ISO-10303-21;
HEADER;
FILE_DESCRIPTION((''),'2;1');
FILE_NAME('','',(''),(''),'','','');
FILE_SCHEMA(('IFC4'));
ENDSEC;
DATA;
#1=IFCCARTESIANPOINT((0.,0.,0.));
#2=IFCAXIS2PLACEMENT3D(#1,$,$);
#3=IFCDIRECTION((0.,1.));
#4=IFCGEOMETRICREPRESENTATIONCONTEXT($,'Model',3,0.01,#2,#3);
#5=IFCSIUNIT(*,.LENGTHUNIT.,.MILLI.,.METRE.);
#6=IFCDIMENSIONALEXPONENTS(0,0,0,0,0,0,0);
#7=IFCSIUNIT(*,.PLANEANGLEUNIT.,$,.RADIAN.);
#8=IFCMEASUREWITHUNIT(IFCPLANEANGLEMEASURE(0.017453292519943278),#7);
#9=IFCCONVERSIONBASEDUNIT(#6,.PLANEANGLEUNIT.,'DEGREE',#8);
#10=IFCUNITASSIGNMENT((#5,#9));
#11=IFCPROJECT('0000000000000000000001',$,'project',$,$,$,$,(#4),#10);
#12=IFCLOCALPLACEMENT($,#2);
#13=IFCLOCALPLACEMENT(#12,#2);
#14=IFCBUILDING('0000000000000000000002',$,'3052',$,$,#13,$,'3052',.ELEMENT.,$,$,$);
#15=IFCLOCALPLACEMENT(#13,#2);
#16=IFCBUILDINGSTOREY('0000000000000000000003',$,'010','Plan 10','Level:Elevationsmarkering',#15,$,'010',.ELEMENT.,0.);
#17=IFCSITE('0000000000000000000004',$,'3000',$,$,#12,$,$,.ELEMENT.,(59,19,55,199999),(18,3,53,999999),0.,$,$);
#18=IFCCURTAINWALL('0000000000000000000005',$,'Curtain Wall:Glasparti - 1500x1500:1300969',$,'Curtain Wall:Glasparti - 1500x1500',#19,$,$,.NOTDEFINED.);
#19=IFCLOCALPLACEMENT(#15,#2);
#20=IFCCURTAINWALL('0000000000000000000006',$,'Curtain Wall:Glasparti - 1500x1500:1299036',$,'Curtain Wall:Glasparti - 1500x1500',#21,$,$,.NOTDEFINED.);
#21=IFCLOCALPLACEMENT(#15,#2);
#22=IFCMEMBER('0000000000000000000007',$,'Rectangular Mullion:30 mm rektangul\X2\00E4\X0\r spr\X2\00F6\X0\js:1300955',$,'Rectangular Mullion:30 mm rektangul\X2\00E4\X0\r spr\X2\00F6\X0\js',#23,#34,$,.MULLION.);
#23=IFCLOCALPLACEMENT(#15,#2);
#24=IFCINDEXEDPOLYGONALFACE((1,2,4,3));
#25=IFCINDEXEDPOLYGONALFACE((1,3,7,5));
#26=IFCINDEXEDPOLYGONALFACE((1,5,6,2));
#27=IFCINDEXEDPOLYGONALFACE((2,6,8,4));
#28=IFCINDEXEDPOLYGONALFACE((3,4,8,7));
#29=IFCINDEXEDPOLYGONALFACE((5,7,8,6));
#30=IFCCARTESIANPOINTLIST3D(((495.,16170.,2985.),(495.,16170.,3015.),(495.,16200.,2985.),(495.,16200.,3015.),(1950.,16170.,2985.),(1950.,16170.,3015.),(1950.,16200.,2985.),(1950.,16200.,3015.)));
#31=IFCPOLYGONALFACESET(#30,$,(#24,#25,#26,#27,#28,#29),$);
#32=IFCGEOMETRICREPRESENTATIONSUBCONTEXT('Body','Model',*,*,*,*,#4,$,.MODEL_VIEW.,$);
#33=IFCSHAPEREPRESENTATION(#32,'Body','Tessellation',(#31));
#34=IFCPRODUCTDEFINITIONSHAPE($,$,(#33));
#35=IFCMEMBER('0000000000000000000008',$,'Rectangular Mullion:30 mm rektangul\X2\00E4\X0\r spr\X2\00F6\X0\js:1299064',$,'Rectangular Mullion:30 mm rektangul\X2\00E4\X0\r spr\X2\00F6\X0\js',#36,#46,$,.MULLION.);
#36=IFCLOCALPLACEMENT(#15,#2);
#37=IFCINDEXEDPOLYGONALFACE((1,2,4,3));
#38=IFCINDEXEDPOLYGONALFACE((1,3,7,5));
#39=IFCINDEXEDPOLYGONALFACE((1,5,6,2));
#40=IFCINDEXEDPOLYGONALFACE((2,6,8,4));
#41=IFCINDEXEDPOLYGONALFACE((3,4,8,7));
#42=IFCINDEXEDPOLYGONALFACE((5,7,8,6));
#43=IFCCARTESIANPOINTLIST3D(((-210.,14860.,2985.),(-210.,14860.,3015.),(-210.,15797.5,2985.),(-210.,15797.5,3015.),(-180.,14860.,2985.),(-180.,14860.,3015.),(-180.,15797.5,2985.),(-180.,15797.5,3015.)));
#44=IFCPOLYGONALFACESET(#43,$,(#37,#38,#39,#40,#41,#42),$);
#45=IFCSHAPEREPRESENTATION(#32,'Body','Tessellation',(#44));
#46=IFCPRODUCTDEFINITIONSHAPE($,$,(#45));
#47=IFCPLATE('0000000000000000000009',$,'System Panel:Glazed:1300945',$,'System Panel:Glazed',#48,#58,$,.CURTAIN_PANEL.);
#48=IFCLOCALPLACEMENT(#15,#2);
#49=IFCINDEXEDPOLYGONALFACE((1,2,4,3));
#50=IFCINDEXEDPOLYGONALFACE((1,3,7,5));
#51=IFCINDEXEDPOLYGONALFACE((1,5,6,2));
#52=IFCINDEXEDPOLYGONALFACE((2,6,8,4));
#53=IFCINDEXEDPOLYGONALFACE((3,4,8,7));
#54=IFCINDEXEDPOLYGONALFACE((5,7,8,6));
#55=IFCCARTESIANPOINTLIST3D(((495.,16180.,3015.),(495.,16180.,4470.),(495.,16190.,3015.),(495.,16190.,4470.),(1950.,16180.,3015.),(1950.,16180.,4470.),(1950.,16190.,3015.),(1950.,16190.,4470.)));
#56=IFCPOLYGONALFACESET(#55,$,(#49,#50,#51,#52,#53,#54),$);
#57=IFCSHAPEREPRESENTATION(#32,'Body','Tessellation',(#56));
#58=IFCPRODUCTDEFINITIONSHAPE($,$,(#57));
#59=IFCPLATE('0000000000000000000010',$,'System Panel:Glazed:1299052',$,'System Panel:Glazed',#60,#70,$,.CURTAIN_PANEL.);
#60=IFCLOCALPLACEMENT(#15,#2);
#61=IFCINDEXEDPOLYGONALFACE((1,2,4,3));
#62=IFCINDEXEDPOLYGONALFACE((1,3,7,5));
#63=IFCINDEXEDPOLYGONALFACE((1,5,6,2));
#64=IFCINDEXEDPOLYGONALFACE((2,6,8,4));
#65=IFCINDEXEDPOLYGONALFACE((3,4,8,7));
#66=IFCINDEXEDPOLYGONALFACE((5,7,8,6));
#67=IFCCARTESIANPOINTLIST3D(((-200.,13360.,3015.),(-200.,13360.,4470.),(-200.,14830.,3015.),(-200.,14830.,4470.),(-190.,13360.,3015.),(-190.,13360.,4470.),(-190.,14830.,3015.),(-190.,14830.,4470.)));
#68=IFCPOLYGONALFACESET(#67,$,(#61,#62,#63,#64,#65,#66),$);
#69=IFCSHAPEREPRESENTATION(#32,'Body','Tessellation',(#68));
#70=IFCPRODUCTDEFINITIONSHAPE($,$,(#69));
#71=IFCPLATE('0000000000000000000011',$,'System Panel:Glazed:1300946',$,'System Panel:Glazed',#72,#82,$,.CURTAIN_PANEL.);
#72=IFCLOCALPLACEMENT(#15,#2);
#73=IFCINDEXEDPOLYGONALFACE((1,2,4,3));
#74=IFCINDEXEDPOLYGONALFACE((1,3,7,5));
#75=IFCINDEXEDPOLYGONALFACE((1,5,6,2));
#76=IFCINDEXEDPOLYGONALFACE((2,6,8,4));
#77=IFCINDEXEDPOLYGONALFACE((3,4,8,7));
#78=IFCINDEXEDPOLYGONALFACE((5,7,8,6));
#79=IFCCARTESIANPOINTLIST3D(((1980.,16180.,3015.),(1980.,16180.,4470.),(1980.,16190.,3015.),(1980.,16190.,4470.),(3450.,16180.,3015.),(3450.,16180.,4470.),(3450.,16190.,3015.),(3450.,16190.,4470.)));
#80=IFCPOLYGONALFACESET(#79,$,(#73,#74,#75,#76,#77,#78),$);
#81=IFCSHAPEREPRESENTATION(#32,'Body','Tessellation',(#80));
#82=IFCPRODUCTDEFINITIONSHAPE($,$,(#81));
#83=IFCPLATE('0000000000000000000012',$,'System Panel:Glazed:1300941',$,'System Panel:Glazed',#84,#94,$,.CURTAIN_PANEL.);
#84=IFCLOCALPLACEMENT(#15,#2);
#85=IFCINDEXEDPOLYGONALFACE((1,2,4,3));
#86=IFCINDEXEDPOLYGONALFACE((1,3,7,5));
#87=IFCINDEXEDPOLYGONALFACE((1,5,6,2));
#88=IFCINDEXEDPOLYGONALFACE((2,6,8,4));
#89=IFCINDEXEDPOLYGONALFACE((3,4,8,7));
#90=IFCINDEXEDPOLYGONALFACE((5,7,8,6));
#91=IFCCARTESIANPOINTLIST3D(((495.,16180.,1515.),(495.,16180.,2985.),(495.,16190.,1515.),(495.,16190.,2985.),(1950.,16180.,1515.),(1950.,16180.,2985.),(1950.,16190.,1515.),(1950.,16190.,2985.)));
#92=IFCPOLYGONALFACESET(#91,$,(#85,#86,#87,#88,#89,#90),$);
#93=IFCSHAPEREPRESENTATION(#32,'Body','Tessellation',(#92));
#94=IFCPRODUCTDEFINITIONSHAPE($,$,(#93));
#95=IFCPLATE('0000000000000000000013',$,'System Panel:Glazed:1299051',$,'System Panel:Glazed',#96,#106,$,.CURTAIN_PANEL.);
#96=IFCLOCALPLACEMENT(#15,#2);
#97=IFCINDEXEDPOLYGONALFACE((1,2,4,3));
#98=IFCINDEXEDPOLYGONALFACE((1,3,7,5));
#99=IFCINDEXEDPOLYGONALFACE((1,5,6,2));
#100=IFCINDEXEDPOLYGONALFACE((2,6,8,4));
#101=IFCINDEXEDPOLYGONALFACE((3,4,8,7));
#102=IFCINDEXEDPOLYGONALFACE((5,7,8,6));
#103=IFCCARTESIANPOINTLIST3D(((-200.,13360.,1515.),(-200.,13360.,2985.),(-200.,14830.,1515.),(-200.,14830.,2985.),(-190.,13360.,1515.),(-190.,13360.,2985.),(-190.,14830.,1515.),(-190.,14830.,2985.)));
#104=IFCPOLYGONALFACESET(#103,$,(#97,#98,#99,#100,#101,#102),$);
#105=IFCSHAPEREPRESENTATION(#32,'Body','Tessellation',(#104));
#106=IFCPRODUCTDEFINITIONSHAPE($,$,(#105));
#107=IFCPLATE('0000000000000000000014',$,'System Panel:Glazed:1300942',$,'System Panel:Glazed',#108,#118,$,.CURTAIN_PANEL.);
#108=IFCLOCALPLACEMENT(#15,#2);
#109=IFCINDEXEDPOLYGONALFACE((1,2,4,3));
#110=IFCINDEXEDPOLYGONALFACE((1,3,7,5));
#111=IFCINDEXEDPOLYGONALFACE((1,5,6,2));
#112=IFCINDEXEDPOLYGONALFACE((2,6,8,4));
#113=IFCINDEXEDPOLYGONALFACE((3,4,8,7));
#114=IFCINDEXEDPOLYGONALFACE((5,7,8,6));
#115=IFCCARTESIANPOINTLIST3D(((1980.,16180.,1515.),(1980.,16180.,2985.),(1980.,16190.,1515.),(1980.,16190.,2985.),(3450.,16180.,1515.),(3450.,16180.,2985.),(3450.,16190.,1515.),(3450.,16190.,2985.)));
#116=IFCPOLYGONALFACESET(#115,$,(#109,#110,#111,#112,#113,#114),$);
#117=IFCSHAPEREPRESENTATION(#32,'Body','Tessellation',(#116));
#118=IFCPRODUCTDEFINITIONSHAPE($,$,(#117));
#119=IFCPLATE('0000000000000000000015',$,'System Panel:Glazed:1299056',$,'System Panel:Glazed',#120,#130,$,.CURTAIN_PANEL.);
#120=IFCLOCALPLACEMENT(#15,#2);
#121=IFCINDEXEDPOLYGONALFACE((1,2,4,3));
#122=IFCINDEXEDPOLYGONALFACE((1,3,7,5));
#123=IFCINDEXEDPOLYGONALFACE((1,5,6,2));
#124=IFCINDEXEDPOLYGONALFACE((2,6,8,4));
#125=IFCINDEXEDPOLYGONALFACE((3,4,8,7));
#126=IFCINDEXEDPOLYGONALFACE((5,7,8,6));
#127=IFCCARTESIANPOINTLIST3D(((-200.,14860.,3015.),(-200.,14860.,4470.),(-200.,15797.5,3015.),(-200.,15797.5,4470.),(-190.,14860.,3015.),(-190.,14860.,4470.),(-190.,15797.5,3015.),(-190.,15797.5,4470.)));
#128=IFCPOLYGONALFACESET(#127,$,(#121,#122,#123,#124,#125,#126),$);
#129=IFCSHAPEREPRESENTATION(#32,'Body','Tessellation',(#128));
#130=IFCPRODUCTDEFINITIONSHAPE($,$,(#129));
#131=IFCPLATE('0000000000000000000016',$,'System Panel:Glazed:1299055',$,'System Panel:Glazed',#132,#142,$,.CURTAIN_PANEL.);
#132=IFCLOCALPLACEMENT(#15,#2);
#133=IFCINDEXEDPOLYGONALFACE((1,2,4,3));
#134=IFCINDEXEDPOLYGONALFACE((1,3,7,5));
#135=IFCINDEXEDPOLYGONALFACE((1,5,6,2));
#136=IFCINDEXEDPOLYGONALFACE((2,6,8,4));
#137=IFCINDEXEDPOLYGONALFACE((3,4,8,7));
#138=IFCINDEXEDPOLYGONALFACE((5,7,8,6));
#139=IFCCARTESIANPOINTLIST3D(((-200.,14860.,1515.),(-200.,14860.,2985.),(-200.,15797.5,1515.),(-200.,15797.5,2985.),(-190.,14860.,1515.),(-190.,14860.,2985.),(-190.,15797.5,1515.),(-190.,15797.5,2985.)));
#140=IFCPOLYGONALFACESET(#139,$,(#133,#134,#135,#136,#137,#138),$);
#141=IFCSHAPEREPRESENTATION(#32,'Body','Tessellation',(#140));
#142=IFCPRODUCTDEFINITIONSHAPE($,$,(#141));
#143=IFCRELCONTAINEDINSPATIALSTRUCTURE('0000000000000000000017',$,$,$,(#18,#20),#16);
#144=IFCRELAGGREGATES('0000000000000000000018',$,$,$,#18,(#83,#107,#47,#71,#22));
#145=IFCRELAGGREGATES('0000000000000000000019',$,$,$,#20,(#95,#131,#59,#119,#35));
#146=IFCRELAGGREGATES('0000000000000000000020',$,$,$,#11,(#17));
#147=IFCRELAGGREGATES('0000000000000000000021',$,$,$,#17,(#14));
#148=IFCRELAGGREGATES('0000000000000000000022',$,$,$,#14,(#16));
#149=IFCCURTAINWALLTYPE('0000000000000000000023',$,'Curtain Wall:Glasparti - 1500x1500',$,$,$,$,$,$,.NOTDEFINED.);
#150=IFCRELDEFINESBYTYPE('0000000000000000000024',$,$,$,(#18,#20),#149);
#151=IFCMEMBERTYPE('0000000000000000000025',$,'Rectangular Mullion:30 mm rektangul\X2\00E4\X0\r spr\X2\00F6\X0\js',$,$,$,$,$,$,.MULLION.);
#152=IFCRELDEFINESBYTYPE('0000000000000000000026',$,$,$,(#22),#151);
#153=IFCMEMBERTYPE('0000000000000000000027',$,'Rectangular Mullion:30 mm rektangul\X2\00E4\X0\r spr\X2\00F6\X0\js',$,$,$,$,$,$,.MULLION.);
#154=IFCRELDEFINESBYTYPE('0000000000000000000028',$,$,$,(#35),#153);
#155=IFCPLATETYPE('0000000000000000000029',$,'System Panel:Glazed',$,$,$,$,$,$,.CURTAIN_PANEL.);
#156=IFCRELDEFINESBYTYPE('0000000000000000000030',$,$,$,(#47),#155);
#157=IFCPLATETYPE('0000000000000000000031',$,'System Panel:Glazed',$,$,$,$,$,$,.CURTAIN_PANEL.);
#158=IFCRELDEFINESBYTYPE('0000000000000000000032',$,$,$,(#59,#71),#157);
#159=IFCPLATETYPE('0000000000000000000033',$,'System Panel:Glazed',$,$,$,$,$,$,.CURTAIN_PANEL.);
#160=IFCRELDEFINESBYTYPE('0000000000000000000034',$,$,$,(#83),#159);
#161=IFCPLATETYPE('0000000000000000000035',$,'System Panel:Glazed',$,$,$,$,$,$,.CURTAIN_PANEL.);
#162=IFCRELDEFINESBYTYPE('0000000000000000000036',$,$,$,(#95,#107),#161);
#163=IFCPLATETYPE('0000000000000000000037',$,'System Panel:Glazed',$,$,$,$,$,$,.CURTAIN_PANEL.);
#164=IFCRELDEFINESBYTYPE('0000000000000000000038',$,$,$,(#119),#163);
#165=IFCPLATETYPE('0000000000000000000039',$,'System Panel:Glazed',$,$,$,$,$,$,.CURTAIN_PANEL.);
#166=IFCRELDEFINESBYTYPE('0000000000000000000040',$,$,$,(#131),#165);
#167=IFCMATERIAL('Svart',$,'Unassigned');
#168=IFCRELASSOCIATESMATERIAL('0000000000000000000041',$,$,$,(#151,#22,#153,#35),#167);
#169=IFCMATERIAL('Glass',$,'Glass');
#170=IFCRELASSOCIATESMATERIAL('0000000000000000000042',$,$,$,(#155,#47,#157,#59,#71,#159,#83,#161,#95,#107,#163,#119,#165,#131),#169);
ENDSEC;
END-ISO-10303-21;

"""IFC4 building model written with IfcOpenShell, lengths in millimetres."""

from ifc_helpers import new_model, entity, si_unit, converted_unit, direction, frame, origin, place, context, subcontext, project, spatial, indexed_curve, outline, extrude, source, transform, mapped, material, type_object, type_shapes, element, aggregate, save


model = new_model("IFC4")

# Units and contexts
model_context = context("Model", 3, precision=0.01, world=origin(), true_north=direction((0.0, 1.0)))
body_context = subcontext(model_context, "Body", "Model", "MODEL_VIEW")
ifc_project = project(units=[si_unit("LENGTHUNIT", "METRE", prefix="MILLI"), converted_unit("PLANEANGLEUNIT", "DEGREE", entity("IfcPlaneAngleMeasure", 0.017453292519943278), si_unit("PLANEANGLEUNIT", "RADIAN"), dimensions=[0, 0, 0, 0, 0, 0, 0])], contexts=[model_context])

# Site, building, storey
site_placement = place(None, origin())
site = spatial("IfcSite", under=ifc_project, at=site_placement, Name="3000", CompositionType="ELEMENT", RefLatitude=(59, 19, 55, 199999), RefLongitude=(18, 3, 53, 999999), RefElevation=0.0)
building_placement = place(site_placement, origin())
building = spatial("IfcBuilding", under=site, at=building_placement, Name="3052", LongName="3052", CompositionType="ELEMENT")
storey_placement = place(building_placement, origin())
storey = spatial("IfcBuildingStorey", under=building, at=storey_placement, Name="010", Description="Plan 10", ObjectType="Level:Elevationsmarkering", LongName="010", CompositionType="ELEMENT", Elevation=0.0)

# Curtain wall
curtain_wall_type = type_object("IfcCurtainWallType", Name="Curtain Wall:Glasparti - 1500x1500", PredefinedType="NOTDEFINED")
curtain_wall_1_placement = place(storey_placement, origin())
curtain_wall_1 = element("IfcCurtainWall", 1, at=curtain_wall_1_placement, inside=storey, type_object=curtain_wall_type, Name="Curtain Wall:Glasparti - 1500x1500:1300969", ObjectType="Curtain Wall:Glasparti - 1500x1500", PredefinedType="NOTDEFINED")
ifc_material_1 = material(Name="Svart", Category="Unassigned")

# Curtain wall
curtain_wall_2_placement = place(storey_placement, origin())
curtain_wall_2 = element("IfcCurtainWall", 2, at=curtain_wall_2_placement, inside=storey, type_object=curtain_wall_type, Name="Curtain Wall:Glasparti - 1500x1500:1299036", ObjectType="Curtain Wall:Glasparti - 1500x1500", PredefinedType="NOTDEFINED")

# Members
member_type_1 = type_object("IfcMemberType", Name="Rectangular Mullion:30 mm rektangulär spröjs", PredefinedType="MULLION", material=ifc_material_1)
shared_shape_1 = source(origin(), body_context, "Body", "SweptSolid", [
    extrude(outline(indexed_curve([(-15.0, -15.0), (15.0, -15.0), (15.0, 15.0), (-15.0, 15.0), (-15.0, -15.0)], self_intersect=False)), frame((0.0, 0.0, -1455.0), z_axis=(0.0, 0.0, 1.0), x_axis=(-1.0, 0.0, 0.0)), (0.0, 0.0, 1.0), 1455.0),
])
type_shapes(member_type_1, [shared_shape_1])
member_1_placement = place(curtain_wall_1_placement, frame((1950.0, 16185.0, 3000.0), z_axis=(1.0, 0.0, 0.0), x_axis=(0.0, 0.0, 1.0)))
member_1 = element("IfcMember", 3, at=member_1_placement, type_object=member_type_1, material=ifc_material_1, Name="Rectangular Mullion:30 mm rektangulär spröjs:1300955", ObjectType="Rectangular Mullion:30 mm rektangulär spröjs", PredefinedType="MULLION", context=body_context, shape_type="MappedRepresentation", body=[
    mapped(shared_shape_1, transform((0.0, 0.0, 0.0), scale=1.0)),
])
member_type_2 = type_object("IfcMemberType", Name="Rectangular Mullion:30 mm rektangulär spröjs", PredefinedType="MULLION", material=ifc_material_1)
shared_shape_2 = source(origin(), body_context, "Body", "SweptSolid", [
    extrude(outline(indexed_curve([(-15.0, -15.0), (15.0, -15.0), (15.0, 15.0), (-15.0, 15.0), (-15.0, -15.0)], self_intersect=False)), frame((0.0, 0.0, -937.5), z_axis=(0.0, 0.0, 1.0), x_axis=(-1.0, 0.0, 0.0)), (0.0, 0.0, 1.0), 937.5),
])
type_shapes(member_type_2, [shared_shape_2])
member_2_placement = place(curtain_wall_2_placement, frame((-195.0, 15797.5, 3000.0), z_axis=(0.0, 1.0, 0.0), x_axis=(0.0, 0.0, 1.0)))
member_2 = element("IfcMember", 4, at=member_2_placement, type_object=member_type_2, material=ifc_material_1, Name="Rectangular Mullion:30 mm rektangulär spröjs:1299064", ObjectType="Rectangular Mullion:30 mm rektangulär spröjs", PredefinedType="MULLION", context=body_context, shape_type="MappedRepresentation", body=[
    mapped(shared_shape_2, transform((0.0, 0.0, 0.0), scale=1.0)),
])

# Plates
ifc_material_2 = material(Name="Glass", Category="Glass")
plate_type_1 = type_object("IfcPlateType", Name="System Panel:Glazed", PredefinedType="CURTAIN_PANEL", material=ifc_material_2)
shared_shape_3 = source(origin(), body_context, "Body", "SweptSolid", [
    extrude(outline(indexed_curve([(-5.0, -727.5), (5.0, -727.5), (5.0, 727.5), (-5.0, 727.5), (-5.0, -727.5)], self_intersect=False)), frame((0.0, 0.0, 0.0), z_axis=(0.0, 0.0, 1.0), x_axis=(0.0, 1.0, 0.0)), (0.0, 0.0, 1.0), 1455.0),
])
type_shapes(plate_type_1, [shared_shape_3])
plate_1_placement = place(curtain_wall_1_placement, frame((1222.5, 16185.0, 3015.0)))
plate_1 = element("IfcPlate", 5, at=plate_1_placement, type_object=plate_type_1, material=ifc_material_2, Name="System Panel:Glazed:1300945", ObjectType="System Panel:Glazed", PredefinedType="CURTAIN_PANEL", context=body_context, shape_type="MappedRepresentation", body=[
    mapped(shared_shape_3, transform((0.0, 0.0, 0.0), scale=1.0)),
])
plate_type_2 = type_object("IfcPlateType", Name="System Panel:Glazed", PredefinedType="CURTAIN_PANEL", material=ifc_material_2)
shared_shape_4 = source(origin(), body_context, "Body", "SweptSolid", [
    extrude(outline(indexed_curve([(-5.0, -735.0), (5.0, -735.0), (5.0, 735.0), (-5.0, 735.0), (-5.0, -735.0)], self_intersect=False)), frame((0.0, 0.0, 0.0), z_axis=(0.0, 0.0, 1.0), x_axis=(0.0, 1.0, 0.0)), (0.0, 0.0, 1.0), 1455.0),
])
type_shapes(plate_type_2, [shared_shape_4])
plate_2_placement = place(curtain_wall_2_placement, frame((-195.0, 14095.0, 3015.0), z_axis=(0.0, 0.0, 1.0), x_axis=(0.0, 1.0, 0.0)))
plate_2 = element("IfcPlate", 6, at=plate_2_placement, type_object=plate_type_2, material=ifc_material_2, Name="System Panel:Glazed:1299052", ObjectType="System Panel:Glazed", PredefinedType="CURTAIN_PANEL", context=body_context, shape_type="MappedRepresentation", body=[
    mapped(shared_shape_4, transform((0.0, 0.0, 0.0), scale=1.0)),
])
plate_3_placement = place(curtain_wall_1_placement, frame((2715.0, 16185.0, 3015.0)))
plate_3 = element("IfcPlate", 7, at=plate_3_placement, type_object=plate_type_2, material=ifc_material_2, Name="System Panel:Glazed:1300946", ObjectType="System Panel:Glazed", PredefinedType="CURTAIN_PANEL", context=body_context, shape_type="MappedRepresentation", body=[
    mapped(shared_shape_4, transform((0.0, 0.0, 0.0), scale=1.0)),
])
plate_type_3 = type_object("IfcPlateType", Name="System Panel:Glazed", PredefinedType="CURTAIN_PANEL", material=ifc_material_2)
shared_shape_5 = source(origin(), body_context, "Body", "SweptSolid", [
    extrude(outline(indexed_curve([(-5.0, -727.5), (5.0, -727.5), (5.0, 727.5), (-5.0, 727.5), (-5.0, -727.5)], self_intersect=False)), frame((0.0, 0.0, 0.0), z_axis=(0.0, 0.0, 1.0), x_axis=(0.0, 1.0, 0.0)), (0.0, 0.0, 1.0), 1470.0),
])
type_shapes(plate_type_3, [shared_shape_5])
plate_4_placement = place(curtain_wall_1_placement, frame((1222.5, 16185.0, 1515.0)))
plate_4 = element("IfcPlate", 8, at=plate_4_placement, type_object=plate_type_3, material=ifc_material_2, Name="System Panel:Glazed:1300941", ObjectType="System Panel:Glazed", PredefinedType="CURTAIN_PANEL", context=body_context, shape_type="MappedRepresentation", body=[
    mapped(shared_shape_5, transform((0.0, 0.0, 0.0), scale=1.0)),
])
plate_type_4 = type_object("IfcPlateType", Name="System Panel:Glazed", PredefinedType="CURTAIN_PANEL", material=ifc_material_2)
shared_shape_6 = source(origin(), body_context, "Body", "SweptSolid", [
    extrude(outline(indexed_curve([(-5.0, -735.0), (5.0, -735.0), (5.0, 735.0), (-5.0, 735.0), (-5.0, -735.0)], self_intersect=False)), frame((0.0, 0.0, 0.0), z_axis=(0.0, 0.0, 1.0), x_axis=(0.0, 1.0, 0.0)), (0.0, 0.0, 1.0), 1470.0),
])
type_shapes(plate_type_4, [shared_shape_6])
plate_5_placement = place(curtain_wall_2_placement, frame((-195.0, 14095.0, 1515.0), z_axis=(0.0, 0.0, 1.0), x_axis=(0.0, 1.0, 0.0)))
plate_5 = element("IfcPlate", 9, at=plate_5_placement, type_object=plate_type_4, material=ifc_material_2, Name="System Panel:Glazed:1299051", ObjectType="System Panel:Glazed", PredefinedType="CURTAIN_PANEL", context=body_context, shape_type="MappedRepresentation", body=[
    mapped(shared_shape_6, transform((0.0, 0.0, 0.0), scale=1.0)),
])
plate_6_placement = place(curtain_wall_1_placement, frame((2715.0, 16185.0, 1515.0)))
plate_6 = element("IfcPlate", 10, at=plate_6_placement, type_object=plate_type_4, material=ifc_material_2, Name="System Panel:Glazed:1300942", ObjectType="System Panel:Glazed", PredefinedType="CURTAIN_PANEL", context=body_context, shape_type="MappedRepresentation", body=[
    mapped(shared_shape_6, transform((0.0, 0.0, 0.0), scale=1.0)),
])
aggregate(curtain_wall_1, [plate_4, plate_6, plate_1, plate_3, member_1])
plate_type_5 = type_object("IfcPlateType", Name="System Panel:Glazed", PredefinedType="CURTAIN_PANEL", material=ifc_material_2)
shared_shape_7 = source(origin(), body_context, "Body", "SweptSolid", [
    extrude(outline(indexed_curve([(-5.0, -468.7), (5.0, -468.7), (5.0, 468.7), (-5.0, 468.7), (-5.0, -468.7)], self_intersect=False)), frame((0.0, 0.0, 0.0), z_axis=(0.0, 0.0, 1.0), x_axis=(0.0, 1.0, 0.0)), (0.0, 0.0, 1.0), 1455.0),
])
type_shapes(plate_type_5, [shared_shape_7])
plate_7_placement = place(curtain_wall_2_placement, frame((-195.0, 15328.8, 3015.0), z_axis=(0.0, 0.0, 1.0), x_axis=(0.0, 1.0, 0.0)))
plate_7 = element("IfcPlate", 11, at=plate_7_placement, type_object=plate_type_5, material=ifc_material_2, Name="System Panel:Glazed:1299056", ObjectType="System Panel:Glazed", PredefinedType="CURTAIN_PANEL", context=body_context, shape_type="MappedRepresentation", body=[
    mapped(shared_shape_7, transform((0.0, 0.0, 0.0), scale=1.0)),
])
plate_type_6 = type_object("IfcPlateType", Name="System Panel:Glazed", PredefinedType="CURTAIN_PANEL", material=ifc_material_2)
shared_shape_8 = source(origin(), body_context, "Body", "SweptSolid", [
    extrude(outline(indexed_curve([(-5.0, -468.7), (5.0, -468.7), (5.0, 468.7), (-5.0, 468.7), (-5.0, -468.7)], self_intersect=False)), frame((0.0, 0.0, 0.0), z_axis=(0.0, 0.0, 1.0), x_axis=(0.0, 1.0, 0.0)), (0.0, 0.0, 1.0), 1470.0),
])
type_shapes(plate_type_6, [shared_shape_8])
plate_8_placement = place(curtain_wall_2_placement, frame((-195.0, 15328.8, 1515.0), z_axis=(0.0, 0.0, 1.0), x_axis=(0.0, 1.0, 0.0)))
plate_8 = element("IfcPlate", 12, at=plate_8_placement, type_object=plate_type_6, material=ifc_material_2, Name="System Panel:Glazed:1299055", ObjectType="System Panel:Glazed", PredefinedType="CURTAIN_PANEL", context=body_context, shape_type="MappedRepresentation", body=[
    mapped(shared_shape_8, transform((0.0, 0.0, 0.0), scale=1.0)),
])
aggregate(curtain_wall_2, [plate_5, plate_8, plate_2, plate_7, member_2])

save(model, "model.ifc")
